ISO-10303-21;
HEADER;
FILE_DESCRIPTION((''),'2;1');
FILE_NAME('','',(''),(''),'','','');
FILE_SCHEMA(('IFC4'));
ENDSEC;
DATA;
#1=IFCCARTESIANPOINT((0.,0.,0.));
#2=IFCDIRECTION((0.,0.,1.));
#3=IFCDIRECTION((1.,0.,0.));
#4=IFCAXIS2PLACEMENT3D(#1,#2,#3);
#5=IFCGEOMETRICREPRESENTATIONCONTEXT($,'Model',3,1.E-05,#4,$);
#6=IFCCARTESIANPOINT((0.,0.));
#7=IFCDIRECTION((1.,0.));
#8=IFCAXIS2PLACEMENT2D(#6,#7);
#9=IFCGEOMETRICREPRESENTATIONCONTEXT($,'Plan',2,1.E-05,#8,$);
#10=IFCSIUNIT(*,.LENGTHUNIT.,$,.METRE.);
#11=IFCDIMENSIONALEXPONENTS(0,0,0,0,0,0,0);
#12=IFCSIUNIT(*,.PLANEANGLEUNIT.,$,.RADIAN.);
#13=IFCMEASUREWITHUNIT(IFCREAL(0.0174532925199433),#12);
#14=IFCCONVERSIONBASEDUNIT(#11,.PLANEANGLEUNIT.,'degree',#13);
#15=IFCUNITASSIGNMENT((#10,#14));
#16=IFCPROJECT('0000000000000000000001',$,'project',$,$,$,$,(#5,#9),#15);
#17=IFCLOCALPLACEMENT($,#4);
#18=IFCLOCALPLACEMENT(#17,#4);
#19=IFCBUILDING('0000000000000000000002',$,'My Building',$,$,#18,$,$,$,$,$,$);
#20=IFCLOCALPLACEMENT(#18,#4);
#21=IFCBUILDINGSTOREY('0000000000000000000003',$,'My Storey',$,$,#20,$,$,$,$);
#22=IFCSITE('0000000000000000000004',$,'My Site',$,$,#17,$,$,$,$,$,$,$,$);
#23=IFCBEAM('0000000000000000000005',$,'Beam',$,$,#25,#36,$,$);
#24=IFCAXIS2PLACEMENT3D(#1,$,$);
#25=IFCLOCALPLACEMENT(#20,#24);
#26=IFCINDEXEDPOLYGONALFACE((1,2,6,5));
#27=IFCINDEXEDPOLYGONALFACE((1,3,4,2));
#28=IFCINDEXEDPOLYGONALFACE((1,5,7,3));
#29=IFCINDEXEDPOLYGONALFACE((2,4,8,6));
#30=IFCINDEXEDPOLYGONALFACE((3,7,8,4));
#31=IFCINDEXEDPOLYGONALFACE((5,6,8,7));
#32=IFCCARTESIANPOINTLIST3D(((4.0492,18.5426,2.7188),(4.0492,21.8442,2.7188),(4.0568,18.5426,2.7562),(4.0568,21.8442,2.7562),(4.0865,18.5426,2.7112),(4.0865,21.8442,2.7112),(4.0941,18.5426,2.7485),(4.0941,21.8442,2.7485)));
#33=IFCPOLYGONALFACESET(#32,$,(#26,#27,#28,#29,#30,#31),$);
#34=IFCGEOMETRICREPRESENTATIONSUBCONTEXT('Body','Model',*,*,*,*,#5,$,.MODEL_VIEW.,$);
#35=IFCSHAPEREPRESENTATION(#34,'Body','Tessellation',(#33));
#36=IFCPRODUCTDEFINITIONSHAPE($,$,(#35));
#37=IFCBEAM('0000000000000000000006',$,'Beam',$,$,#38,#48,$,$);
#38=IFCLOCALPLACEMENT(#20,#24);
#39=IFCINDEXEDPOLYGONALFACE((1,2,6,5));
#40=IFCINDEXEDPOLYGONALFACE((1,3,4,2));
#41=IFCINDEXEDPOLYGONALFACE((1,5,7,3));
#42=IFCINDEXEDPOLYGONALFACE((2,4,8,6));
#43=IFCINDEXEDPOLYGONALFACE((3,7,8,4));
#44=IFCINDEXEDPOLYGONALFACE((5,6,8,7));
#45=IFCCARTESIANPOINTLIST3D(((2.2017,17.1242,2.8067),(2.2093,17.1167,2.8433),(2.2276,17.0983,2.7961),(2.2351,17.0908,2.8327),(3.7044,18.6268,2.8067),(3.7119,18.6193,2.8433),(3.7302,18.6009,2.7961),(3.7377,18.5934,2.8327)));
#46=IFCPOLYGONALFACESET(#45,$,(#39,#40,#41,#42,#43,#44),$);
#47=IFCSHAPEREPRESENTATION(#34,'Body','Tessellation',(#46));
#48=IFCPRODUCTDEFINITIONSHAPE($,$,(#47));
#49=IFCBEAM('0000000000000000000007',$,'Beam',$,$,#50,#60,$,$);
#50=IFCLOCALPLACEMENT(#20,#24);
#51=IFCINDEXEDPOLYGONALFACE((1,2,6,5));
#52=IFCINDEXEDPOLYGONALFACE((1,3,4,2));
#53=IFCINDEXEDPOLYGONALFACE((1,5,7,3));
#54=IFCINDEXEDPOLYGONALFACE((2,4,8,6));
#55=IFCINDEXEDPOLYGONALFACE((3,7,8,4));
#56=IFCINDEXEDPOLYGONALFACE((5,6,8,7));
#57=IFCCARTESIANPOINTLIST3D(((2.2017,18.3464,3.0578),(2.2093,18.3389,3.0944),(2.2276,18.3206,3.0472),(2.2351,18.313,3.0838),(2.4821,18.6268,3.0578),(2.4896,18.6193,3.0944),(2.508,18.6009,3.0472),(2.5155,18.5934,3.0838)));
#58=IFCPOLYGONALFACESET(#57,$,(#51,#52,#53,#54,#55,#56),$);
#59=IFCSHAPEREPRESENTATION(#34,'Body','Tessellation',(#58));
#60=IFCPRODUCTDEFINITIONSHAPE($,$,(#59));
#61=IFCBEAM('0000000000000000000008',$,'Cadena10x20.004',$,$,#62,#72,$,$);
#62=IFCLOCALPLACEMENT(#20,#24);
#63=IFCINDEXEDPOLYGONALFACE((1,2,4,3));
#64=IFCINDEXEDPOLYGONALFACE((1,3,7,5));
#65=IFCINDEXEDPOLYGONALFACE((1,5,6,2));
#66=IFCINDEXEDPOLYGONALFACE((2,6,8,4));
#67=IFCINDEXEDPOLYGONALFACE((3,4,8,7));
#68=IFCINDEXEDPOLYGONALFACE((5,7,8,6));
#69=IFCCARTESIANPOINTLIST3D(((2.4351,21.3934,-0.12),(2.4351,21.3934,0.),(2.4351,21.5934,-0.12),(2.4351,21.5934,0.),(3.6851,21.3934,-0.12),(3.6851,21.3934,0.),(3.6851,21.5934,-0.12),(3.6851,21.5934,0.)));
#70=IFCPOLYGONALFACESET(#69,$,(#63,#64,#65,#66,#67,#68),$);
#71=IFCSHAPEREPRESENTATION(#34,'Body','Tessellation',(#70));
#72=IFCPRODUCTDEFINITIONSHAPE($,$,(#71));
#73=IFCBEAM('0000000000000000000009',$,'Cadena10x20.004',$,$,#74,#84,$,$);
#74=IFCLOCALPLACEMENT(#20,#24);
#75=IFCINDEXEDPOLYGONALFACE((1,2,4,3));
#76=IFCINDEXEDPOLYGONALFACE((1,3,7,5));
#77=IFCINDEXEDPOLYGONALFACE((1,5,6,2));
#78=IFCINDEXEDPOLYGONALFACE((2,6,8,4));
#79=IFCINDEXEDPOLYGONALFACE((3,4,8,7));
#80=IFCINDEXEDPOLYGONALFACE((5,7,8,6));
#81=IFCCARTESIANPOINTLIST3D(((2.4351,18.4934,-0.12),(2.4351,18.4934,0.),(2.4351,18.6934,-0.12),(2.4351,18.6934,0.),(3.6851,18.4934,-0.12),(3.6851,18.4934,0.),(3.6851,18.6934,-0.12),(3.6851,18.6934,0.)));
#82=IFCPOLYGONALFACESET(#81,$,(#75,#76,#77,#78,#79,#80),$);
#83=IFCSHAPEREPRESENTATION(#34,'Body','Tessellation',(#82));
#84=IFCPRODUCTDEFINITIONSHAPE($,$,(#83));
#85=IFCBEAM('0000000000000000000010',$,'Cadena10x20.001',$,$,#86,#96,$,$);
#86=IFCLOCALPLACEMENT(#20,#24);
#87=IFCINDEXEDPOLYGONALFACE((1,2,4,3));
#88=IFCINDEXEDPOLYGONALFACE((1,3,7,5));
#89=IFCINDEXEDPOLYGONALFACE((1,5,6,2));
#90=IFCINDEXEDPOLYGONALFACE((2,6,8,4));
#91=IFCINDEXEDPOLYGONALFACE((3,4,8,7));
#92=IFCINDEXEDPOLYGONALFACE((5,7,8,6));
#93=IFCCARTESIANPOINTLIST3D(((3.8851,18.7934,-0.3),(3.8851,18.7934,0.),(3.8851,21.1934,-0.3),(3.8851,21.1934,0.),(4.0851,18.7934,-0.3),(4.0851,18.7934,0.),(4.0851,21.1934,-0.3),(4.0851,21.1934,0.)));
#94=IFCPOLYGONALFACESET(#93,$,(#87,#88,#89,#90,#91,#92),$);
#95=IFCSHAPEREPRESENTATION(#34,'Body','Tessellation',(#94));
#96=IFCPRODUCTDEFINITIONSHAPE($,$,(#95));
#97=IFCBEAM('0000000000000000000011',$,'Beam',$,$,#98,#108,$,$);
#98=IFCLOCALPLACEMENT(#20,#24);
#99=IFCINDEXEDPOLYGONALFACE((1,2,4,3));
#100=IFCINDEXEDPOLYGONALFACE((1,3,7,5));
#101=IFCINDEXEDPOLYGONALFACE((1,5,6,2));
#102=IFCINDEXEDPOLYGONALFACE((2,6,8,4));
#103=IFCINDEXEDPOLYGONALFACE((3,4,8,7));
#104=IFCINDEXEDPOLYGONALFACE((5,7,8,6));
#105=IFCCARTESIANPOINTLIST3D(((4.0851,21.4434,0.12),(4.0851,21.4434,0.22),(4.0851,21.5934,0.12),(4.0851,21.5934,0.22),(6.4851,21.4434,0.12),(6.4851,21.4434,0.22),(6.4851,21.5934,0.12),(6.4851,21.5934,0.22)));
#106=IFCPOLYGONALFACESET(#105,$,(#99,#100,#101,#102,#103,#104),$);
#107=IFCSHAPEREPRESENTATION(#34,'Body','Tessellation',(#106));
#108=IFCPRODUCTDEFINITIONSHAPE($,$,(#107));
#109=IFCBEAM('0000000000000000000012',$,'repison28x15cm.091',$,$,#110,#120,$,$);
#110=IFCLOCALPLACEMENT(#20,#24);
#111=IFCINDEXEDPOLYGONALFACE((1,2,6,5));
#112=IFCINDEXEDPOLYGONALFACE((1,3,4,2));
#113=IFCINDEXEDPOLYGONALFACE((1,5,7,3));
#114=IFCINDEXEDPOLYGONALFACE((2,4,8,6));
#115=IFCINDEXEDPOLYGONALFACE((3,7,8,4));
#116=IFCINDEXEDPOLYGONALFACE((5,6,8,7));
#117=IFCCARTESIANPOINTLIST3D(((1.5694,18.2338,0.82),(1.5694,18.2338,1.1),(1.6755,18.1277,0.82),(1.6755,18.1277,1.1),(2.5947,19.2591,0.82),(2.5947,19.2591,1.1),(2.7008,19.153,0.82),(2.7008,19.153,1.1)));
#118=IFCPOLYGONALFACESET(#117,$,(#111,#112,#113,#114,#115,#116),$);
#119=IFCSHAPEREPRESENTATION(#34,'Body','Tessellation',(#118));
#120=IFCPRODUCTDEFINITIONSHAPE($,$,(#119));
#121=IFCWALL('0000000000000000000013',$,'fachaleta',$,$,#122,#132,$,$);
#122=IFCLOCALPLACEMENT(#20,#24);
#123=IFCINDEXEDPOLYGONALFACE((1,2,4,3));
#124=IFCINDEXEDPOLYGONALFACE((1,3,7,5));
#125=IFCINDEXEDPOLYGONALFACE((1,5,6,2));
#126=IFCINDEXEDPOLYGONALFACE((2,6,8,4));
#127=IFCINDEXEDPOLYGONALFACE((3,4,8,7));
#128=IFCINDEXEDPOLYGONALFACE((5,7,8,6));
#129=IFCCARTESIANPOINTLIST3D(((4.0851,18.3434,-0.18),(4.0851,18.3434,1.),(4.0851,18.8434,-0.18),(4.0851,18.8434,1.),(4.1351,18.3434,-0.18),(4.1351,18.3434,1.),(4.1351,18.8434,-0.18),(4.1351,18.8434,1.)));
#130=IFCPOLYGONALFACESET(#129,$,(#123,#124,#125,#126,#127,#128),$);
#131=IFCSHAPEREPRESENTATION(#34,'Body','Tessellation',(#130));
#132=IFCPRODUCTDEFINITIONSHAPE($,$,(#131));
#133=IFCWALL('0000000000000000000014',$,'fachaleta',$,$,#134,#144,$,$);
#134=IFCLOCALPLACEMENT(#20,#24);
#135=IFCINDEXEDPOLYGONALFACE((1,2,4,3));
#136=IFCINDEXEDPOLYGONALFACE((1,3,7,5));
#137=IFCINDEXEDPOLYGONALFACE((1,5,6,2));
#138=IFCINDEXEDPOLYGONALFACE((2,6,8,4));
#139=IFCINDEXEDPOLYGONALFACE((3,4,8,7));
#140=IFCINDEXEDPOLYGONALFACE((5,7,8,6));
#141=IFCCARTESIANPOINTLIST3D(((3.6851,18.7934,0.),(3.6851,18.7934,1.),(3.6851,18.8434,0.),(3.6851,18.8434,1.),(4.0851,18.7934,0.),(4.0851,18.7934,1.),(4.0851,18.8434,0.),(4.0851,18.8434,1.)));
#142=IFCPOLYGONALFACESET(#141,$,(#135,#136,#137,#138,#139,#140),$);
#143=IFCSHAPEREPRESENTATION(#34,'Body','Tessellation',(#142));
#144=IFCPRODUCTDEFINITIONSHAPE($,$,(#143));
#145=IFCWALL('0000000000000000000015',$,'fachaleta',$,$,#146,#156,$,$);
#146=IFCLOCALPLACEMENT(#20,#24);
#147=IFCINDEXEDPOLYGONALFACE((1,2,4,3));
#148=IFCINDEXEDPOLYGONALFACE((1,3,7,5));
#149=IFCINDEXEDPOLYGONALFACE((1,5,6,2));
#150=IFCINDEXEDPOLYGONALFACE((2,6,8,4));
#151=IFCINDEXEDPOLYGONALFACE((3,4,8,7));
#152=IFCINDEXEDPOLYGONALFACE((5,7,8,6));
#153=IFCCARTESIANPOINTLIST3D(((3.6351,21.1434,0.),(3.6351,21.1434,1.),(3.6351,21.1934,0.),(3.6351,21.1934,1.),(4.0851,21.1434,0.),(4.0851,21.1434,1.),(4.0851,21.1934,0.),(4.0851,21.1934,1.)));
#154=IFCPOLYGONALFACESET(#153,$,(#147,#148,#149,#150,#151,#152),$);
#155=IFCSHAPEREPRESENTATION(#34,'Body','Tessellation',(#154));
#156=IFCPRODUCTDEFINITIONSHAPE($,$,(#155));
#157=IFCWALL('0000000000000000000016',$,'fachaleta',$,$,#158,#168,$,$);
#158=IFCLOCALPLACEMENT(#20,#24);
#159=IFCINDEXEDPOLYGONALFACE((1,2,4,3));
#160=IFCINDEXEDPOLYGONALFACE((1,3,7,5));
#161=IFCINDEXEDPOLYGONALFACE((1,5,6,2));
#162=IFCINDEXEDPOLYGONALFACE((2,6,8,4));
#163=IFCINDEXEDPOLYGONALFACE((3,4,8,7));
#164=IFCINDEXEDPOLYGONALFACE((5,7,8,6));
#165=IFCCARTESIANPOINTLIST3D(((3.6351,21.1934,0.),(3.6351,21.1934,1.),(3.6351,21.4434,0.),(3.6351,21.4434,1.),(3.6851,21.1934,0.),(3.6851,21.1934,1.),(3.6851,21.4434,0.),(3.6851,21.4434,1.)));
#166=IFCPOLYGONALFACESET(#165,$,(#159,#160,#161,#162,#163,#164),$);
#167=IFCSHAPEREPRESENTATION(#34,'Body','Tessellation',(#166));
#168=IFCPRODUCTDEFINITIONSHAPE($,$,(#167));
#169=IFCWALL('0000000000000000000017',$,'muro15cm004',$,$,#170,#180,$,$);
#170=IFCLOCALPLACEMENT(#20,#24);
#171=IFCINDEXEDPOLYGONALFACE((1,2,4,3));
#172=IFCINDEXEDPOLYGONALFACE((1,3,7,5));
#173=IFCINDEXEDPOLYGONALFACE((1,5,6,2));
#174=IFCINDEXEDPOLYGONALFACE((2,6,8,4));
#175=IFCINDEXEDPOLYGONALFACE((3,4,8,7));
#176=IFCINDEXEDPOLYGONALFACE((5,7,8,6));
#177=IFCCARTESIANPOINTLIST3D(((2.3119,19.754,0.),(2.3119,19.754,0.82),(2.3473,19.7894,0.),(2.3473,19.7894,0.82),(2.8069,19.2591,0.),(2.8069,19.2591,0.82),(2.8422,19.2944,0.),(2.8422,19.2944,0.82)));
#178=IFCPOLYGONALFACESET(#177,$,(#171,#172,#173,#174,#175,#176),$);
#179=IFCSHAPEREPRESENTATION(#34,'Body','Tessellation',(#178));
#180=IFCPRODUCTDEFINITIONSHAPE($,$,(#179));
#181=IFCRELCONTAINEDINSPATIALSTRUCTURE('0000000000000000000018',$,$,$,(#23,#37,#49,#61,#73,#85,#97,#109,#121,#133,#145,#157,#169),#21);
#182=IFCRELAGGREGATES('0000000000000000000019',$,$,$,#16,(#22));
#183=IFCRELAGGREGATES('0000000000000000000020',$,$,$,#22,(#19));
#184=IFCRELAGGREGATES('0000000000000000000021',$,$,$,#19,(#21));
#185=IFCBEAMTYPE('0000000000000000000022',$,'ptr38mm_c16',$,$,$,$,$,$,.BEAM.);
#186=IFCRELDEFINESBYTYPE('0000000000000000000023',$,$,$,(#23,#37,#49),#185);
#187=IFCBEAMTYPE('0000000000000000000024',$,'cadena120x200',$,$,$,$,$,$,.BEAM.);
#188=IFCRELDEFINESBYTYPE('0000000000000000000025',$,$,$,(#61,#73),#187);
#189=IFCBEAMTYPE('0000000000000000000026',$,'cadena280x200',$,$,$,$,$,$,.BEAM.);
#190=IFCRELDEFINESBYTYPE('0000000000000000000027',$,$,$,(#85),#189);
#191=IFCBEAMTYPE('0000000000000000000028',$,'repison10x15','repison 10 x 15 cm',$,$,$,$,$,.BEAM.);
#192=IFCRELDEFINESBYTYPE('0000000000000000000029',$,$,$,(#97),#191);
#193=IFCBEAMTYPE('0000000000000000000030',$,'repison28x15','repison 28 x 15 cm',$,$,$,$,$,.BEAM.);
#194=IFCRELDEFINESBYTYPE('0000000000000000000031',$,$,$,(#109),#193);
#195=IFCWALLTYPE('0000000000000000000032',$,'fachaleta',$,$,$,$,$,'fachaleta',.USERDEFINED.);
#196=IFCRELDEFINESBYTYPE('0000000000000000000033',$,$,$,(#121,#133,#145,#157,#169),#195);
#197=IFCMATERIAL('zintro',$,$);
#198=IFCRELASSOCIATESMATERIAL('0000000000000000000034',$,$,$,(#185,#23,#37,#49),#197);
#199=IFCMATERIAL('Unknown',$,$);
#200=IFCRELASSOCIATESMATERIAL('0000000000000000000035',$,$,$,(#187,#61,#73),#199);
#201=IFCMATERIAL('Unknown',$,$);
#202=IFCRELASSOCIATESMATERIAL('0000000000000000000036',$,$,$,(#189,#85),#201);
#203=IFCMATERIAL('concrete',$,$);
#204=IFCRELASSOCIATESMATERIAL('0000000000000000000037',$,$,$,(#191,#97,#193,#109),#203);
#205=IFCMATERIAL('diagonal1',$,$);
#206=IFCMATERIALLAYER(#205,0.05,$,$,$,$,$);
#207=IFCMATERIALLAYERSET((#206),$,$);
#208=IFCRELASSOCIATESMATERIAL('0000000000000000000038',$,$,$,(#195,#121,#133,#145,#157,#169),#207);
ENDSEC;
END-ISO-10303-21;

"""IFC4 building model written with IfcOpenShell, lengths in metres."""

from ifc_helpers import new_model, entity, si_unit, converted_unit, frame, origin_with_axes, origin_2d_with_axis, place, context, subcontext, project, spatial, indexed_curve, rectangle, outline, extrude, material, layer, layer_set, layer_usage, material_profile, profile_set, profile_usage, type_object, element, save


model = new_model("IFC4")

# Units and contexts
model_context = context("Model", 3, precision=1e-05, world=origin_with_axes())
plan_context = context("Plan", 2, precision=1e-05, world=origin_2d_with_axis())
body_context = subcontext(model_context, "Body", "Model", "MODEL_VIEW")
ifc_project = project(units=[si_unit("LENGTHUNIT", "METRE"), converted_unit("PLANEANGLEUNIT", "degree", entity("IfcReal", 0.0174532925199433), si_unit("PLANEANGLEUNIT", "RADIAN"), dimensions=[0, 0, 0, 0, 0, 0, 0])], contexts=[model_context, plan_context])

# Site, building, storey
site_placement = place(None, origin_with_axes())
site = spatial("IfcSite", under=ifc_project, at=site_placement, Name="My Site")
building_placement = place(site_placement, origin_with_axes())
building = spatial("IfcBuilding", under=site, at=building_placement, Name="My Building")
storey_placement = place(building_placement, origin_with_axes())
storey = spatial("IfcBuildingStorey", under=building, at=storey_placement, Name="My Storey")

# Shared definitions
ifc_material_1 = material(Name="concrete")

# Beams
ifc_material_2 = material(Name="zintro")
ifc_material_profile_1 = material_profile(ifc_material_2, rectangle(XDim=0.0381, YDim=0.0381))
ifc_profile_set_1 = profile_set([ifc_material_profile_1])
beam_type_1 = type_object("IfcBeamType", Name="ptr38mm_c16", PredefinedType="BEAM", material=ifc_profile_set_1)
ifc_profile_usage_1 = profile_usage(ifc_profile_set_1)
beam_1_placement = place(storey_placement, frame((4.0717, 21.8442, 2.7337), z_axis=(0.0, -1.0, 0.0), x_axis=(0.979575, 0.0, -0.201078)))
element("IfcBeam", 1, at=beam_1_placement, inside=storey, type_object=beam_type_1, material=ifc_profile_usage_1, Name="Beam", context=body_context, shape_type="SweptSolid", body=[
    extrude(rectangle(XDim=0.0381, YDim=0.0381), origin_with_axes(), (0.0, 0.0, 1.0), 3.3016),
])
ifc_profile_usage_2 = profile_usage(ifc_profile_set_1)
beam_2_placement = place(storey_placement, frame((3.721, 18.6101, 2.8197), z_axis=(-0.707107, -0.707107, 0.0), x_axis=(0.67903, -0.67903, -0.278991)))
element("IfcBeam", 2, at=beam_2_placement, inside=storey, type_object=beam_type_1, material=ifc_profile_usage_2, Name="Beam", context=body_context, shape_type="SweptSolid", body=[
    extrude(rectangle(XDim=0.0381, YDim=0.0381), origin_with_axes(), (0.0, 0.0, 1.0), 2.125),
])
ifc_profile_usage_3 = profile_usage(ifc_profile_set_1)
beam_3_placement = place(storey_placement, frame((2.4988, 18.6101, 3.0708), z_axis=(-0.707107, -0.707107, 0.0), x_axis=(0.67903, -0.67903, -0.278991)))
element("IfcBeam", 3, at=beam_3_placement, inside=storey, type_object=beam_type_1, material=ifc_profile_usage_3, Name="Beam", context=body_context, shape_type="SweptSolid", body=[
    extrude(rectangle(XDim=0.0381, YDim=0.0381), origin_with_axes(), (0.0, 0.0, 1.0), 0.3965),
])
ifc_material_3 = material(Name="Unknown")
ifc_material_profile_2 = material_profile(ifc_material_3, rectangle(XDim=0.2, YDim=0.12))
ifc_profile_set_2 = profile_set([ifc_material_profile_2], Name="concrete")
ifc_profile_usage_4 = profile_usage(ifc_profile_set_2, cardinal=5)
beam_type_2 = type_object("IfcBeamType", Name="cadena120x200", PredefinedType="BEAM", material=ifc_profile_set_2)
beam_4_placement = place(storey_placement, frame((2.4351, 21.4934, -0.06), z_axis=(1.0, -0.000001, 0.000001), x_axis=(0.000001, 1.0, 0.0)))
element("IfcBeam", 4, at=beam_4_placement, inside=storey, type_object=beam_type_2, material=ifc_profile_usage_4, Name="Cadena10x20.004", context=body_context, shape_type="SweptSolid", body=[
    extrude(rectangle(XDim=0.2, YDim=0.12), origin_with_axes(), (0.0, 0.0, 1.0), 1.25),
])
ifc_profile_usage_5 = profile_usage(ifc_profile_set_2, cardinal=5)
beam_5_placement = place(storey_placement, frame((2.4351, 18.5934, -0.06), z_axis=(1.0, -0.000001, 0.000001), x_axis=(0.000001, 1.0, 0.0)))
element("IfcBeam", 5, at=beam_5_placement, inside=storey, type_object=beam_type_2, material=ifc_profile_usage_5, Name="Cadena10x20.004", context=body_context, shape_type="SweptSolid", body=[
    extrude(rectangle(XDim=0.2, YDim=0.12), origin_with_axes(), (0.0, 0.0, 1.0), 1.25),
])
ifc_material_4 = material(Name="Unknown")
ifc_material_profile_3 = material_profile(ifc_material_4, rectangle(XDim=0.2, YDim=0.3))
ifc_profile_set_3 = profile_set([ifc_material_profile_3], Name="concrete")
ifc_profile_usage_6 = profile_usage(ifc_profile_set_3)
beam_type_3 = type_object("IfcBeamType", Name="cadena280x200", PredefinedType="BEAM", material=ifc_profile_set_3)
beam_6_placement = place(storey_placement, frame((3.9851, 21.1934, -0.15), z_axis=(0.0, -1.0, 0.0), x_axis=(1.0, 0.0, 0.0)))
element("IfcBeam", 6, at=beam_6_placement, inside=storey, type_object=beam_type_3, material=ifc_profile_usage_6, Name="Cadena10x20.001", context=body_context, shape_type="SweptSolid", body=[
    extrude(rectangle(XDim=0.2, YDim=0.3), origin_with_axes(), (0.0, 0.0, 1.0), 2.4),
])
ifc_material_profile_4 = material_profile(ifc_material_1, rectangle(XDim=0.15, YDim=0.1))
ifc_profile_set_4 = profile_set([ifc_material_profile_4])
ifc_profile_usage_7 = profile_usage(ifc_profile_set_4, cardinal=5)
beam_type_4 = type_object("IfcBeamType", Name="repison10x15", Description="repison 10 x 15 cm", PredefinedType="BEAM", material=ifc_profile_set_4)
beam_7_placement = place(storey_placement, frame((4.0851, 21.5184, 0.17), z_axis=(1.0, 0.0, 0.0), x_axis=(0.0, 1.0, 0.0)))
element("IfcBeam", 7, at=beam_7_placement, inside=storey, type_object=beam_type_4, material=ifc_profile_usage_7, Name="Beam", context=body_context, shape_type="SweptSolid", body=[
    extrude(rectangle(XDim=0.15, YDim=0.1), origin_with_axes(), (0.0, 0.0, 1.0), 2.4),
])
ifc_material_profile_5 = material_profile(ifc_material_1, rectangle(XDim=0.15, YDim=0.28))
ifc_profile_set_5 = profile_set([ifc_material_profile_5])
ifc_profile_usage_8 = profile_usage(ifc_profile_set_5, cardinal=5)
beam_type_5 = type_object("IfcBeamType", Name="repison28x15", Description="repison 28 x 15 cm", PredefinedType="BEAM", material=ifc_profile_set_5)
beam_8_placement = place(storey_placement, frame((2.6478, 19.206, 0.96), z_axis=(-0.707107, -0.707107, 0.0), x_axis=(0.707107, -0.707107, 0.0)))
element("IfcBeam", 8, at=beam_8_placement, inside=storey, type_object=beam_type_5, material=ifc_profile_usage_8, Name="repison28x15cm.091", context=body_context, shape_type="SweptSolid", body=[
    extrude(rectangle(XDim=0.15, YDim=0.28), origin_with_axes(), (0.0, 0.0, 1.0), 1.45),
])

# Walls
ifc_material_5 = material(Name="diagonal1")
ifc_layer_1 = layer(ifc_material_5, 0.05)
ifc_layer_set_1 = layer_set([ifc_layer_1])
ifc_layer_usage_1 = layer_usage(ifc_layer_set_1, "AXIS2", "POSITIVE", 0.0)
wall_type_1 = type_object("IfcWallType", Name="fachaleta", ElementType="fachaleta", PredefinedType="USERDEFINED", material=ifc_layer_set_1)
wall_1_placement = place(storey_placement, frame((4.0851, 18.8434, -0.18), z_axis=(0.0, 0.0, 1.0), x_axis=(0.0, -1.0, 0.0)))
element("IfcWall", 9, at=wall_1_placement, inside=storey, type_object=wall_type_1, material=ifc_layer_usage_1, Name="fachaleta", context=body_context, shape_type="SweptSolid", body=[
    extrude(outline(indexed_curve([(0.0, 0.0), (0.0, 0.05), (0.5, 0.05), (0.5, 0.0), (0.0, 0.0)], self_intersect=False)), origin_with_axes(), (0.0, 0.0, 1.0), 1.18),
])
ifc_layer_usage_2 = layer_usage(ifc_layer_set_1, "AXIS2", "POSITIVE", 0.0)
wall_2_placement = place(storey_placement, frame((3.6851, 18.7934, 0.0), z_axis=(0.0, 0.0, 1.0), x_axis=(1.0, 0.0, 0.0)))
element("IfcWall", 10, at=wall_2_placement, inside=storey, type_object=wall_type_1, material=ifc_layer_usage_2, Name="fachaleta", context=body_context, shape_type="SweptSolid", body=[
    extrude(outline(indexed_curve([(0.0, 0.0), (0.0, 0.05), (0.4, 0.05), (0.4, 0.0), (0.0, 0.0)], self_intersect=False)), origin_with_axes(), (0.0, 0.0, 1.0), 1.0),
])
ifc_layer_usage_3 = layer_usage(ifc_layer_set_1, "AXIS2", "POSITIVE", 0.0)
wall_3_placement = place(storey_placement, frame((4.0851, 21.1934, 0.0), z_axis=(0.0, 0.0, 1.0), x_axis=(-1.0, 0.000001, 0.0)))
element("IfcWall", 11, at=wall_3_placement, inside=storey, type_object=wall_type_1, material=ifc_layer_usage_3, Name="fachaleta", context=body_context, shape_type="SweptSolid", body=[
    extrude(outline(indexed_curve([(0.0, 0.0), (0.0, 0.05), (0.45, 0.05), (0.45, 0.0), (0.0, 0.0)], self_intersect=False)), origin_with_axes(), (0.0, 0.0, 1.0), 1.0),
])
ifc_layer_usage_4 = layer_usage(ifc_layer_set_1, "AXIS2", "POSITIVE", 0.0)
wall_4_placement = place(storey_placement, frame((3.6851, 21.1934, 0.0), z_axis=(0.0, 0.0, 1.0), x_axis=(0.000001, 1.0, 0.0)))
element("IfcWall", 12, at=wall_4_placement, inside=storey, type_object=wall_type_1, material=ifc_layer_usage_4, Name="fachaleta", context=body_context, shape_type="SweptSolid", body=[
    extrude(outline(indexed_curve([(0.0, 0.0), (0.0, 0.05), (0.25, 0.05), (0.25, 0.0), (0.0, 0.0)], self_intersect=False)), origin_with_axes(), (0.0, 0.0, 1.0), 1.0),
])
ifc_layer_usage_5 = layer_usage(ifc_layer_set_1, "AXIS2", "POSITIVE", 0.0)
wall_5_placement = place(storey_placement, frame((2.3119, 19.754, 0.0), z_axis=(0.0, 0.0, 1.0), x_axis=(0.707107, -0.707107, 0.0)))
element("IfcWall", 13, at=wall_5_placement, inside=storey, type_object=wall_type_1, material=ifc_layer_usage_5, Name="muro15cm004", context=body_context, shape_type="SweptSolid", body=[
    extrude(outline(indexed_curve([(0.0, 0.0), (0.0, 0.05), (0.7, 0.05), (0.7, 0.0), (0.0, 0.0)], self_intersect=False)), origin_with_axes(), (0.0, 0.0, 1.0), 0.82),
])

save(model, "model.ifc")
